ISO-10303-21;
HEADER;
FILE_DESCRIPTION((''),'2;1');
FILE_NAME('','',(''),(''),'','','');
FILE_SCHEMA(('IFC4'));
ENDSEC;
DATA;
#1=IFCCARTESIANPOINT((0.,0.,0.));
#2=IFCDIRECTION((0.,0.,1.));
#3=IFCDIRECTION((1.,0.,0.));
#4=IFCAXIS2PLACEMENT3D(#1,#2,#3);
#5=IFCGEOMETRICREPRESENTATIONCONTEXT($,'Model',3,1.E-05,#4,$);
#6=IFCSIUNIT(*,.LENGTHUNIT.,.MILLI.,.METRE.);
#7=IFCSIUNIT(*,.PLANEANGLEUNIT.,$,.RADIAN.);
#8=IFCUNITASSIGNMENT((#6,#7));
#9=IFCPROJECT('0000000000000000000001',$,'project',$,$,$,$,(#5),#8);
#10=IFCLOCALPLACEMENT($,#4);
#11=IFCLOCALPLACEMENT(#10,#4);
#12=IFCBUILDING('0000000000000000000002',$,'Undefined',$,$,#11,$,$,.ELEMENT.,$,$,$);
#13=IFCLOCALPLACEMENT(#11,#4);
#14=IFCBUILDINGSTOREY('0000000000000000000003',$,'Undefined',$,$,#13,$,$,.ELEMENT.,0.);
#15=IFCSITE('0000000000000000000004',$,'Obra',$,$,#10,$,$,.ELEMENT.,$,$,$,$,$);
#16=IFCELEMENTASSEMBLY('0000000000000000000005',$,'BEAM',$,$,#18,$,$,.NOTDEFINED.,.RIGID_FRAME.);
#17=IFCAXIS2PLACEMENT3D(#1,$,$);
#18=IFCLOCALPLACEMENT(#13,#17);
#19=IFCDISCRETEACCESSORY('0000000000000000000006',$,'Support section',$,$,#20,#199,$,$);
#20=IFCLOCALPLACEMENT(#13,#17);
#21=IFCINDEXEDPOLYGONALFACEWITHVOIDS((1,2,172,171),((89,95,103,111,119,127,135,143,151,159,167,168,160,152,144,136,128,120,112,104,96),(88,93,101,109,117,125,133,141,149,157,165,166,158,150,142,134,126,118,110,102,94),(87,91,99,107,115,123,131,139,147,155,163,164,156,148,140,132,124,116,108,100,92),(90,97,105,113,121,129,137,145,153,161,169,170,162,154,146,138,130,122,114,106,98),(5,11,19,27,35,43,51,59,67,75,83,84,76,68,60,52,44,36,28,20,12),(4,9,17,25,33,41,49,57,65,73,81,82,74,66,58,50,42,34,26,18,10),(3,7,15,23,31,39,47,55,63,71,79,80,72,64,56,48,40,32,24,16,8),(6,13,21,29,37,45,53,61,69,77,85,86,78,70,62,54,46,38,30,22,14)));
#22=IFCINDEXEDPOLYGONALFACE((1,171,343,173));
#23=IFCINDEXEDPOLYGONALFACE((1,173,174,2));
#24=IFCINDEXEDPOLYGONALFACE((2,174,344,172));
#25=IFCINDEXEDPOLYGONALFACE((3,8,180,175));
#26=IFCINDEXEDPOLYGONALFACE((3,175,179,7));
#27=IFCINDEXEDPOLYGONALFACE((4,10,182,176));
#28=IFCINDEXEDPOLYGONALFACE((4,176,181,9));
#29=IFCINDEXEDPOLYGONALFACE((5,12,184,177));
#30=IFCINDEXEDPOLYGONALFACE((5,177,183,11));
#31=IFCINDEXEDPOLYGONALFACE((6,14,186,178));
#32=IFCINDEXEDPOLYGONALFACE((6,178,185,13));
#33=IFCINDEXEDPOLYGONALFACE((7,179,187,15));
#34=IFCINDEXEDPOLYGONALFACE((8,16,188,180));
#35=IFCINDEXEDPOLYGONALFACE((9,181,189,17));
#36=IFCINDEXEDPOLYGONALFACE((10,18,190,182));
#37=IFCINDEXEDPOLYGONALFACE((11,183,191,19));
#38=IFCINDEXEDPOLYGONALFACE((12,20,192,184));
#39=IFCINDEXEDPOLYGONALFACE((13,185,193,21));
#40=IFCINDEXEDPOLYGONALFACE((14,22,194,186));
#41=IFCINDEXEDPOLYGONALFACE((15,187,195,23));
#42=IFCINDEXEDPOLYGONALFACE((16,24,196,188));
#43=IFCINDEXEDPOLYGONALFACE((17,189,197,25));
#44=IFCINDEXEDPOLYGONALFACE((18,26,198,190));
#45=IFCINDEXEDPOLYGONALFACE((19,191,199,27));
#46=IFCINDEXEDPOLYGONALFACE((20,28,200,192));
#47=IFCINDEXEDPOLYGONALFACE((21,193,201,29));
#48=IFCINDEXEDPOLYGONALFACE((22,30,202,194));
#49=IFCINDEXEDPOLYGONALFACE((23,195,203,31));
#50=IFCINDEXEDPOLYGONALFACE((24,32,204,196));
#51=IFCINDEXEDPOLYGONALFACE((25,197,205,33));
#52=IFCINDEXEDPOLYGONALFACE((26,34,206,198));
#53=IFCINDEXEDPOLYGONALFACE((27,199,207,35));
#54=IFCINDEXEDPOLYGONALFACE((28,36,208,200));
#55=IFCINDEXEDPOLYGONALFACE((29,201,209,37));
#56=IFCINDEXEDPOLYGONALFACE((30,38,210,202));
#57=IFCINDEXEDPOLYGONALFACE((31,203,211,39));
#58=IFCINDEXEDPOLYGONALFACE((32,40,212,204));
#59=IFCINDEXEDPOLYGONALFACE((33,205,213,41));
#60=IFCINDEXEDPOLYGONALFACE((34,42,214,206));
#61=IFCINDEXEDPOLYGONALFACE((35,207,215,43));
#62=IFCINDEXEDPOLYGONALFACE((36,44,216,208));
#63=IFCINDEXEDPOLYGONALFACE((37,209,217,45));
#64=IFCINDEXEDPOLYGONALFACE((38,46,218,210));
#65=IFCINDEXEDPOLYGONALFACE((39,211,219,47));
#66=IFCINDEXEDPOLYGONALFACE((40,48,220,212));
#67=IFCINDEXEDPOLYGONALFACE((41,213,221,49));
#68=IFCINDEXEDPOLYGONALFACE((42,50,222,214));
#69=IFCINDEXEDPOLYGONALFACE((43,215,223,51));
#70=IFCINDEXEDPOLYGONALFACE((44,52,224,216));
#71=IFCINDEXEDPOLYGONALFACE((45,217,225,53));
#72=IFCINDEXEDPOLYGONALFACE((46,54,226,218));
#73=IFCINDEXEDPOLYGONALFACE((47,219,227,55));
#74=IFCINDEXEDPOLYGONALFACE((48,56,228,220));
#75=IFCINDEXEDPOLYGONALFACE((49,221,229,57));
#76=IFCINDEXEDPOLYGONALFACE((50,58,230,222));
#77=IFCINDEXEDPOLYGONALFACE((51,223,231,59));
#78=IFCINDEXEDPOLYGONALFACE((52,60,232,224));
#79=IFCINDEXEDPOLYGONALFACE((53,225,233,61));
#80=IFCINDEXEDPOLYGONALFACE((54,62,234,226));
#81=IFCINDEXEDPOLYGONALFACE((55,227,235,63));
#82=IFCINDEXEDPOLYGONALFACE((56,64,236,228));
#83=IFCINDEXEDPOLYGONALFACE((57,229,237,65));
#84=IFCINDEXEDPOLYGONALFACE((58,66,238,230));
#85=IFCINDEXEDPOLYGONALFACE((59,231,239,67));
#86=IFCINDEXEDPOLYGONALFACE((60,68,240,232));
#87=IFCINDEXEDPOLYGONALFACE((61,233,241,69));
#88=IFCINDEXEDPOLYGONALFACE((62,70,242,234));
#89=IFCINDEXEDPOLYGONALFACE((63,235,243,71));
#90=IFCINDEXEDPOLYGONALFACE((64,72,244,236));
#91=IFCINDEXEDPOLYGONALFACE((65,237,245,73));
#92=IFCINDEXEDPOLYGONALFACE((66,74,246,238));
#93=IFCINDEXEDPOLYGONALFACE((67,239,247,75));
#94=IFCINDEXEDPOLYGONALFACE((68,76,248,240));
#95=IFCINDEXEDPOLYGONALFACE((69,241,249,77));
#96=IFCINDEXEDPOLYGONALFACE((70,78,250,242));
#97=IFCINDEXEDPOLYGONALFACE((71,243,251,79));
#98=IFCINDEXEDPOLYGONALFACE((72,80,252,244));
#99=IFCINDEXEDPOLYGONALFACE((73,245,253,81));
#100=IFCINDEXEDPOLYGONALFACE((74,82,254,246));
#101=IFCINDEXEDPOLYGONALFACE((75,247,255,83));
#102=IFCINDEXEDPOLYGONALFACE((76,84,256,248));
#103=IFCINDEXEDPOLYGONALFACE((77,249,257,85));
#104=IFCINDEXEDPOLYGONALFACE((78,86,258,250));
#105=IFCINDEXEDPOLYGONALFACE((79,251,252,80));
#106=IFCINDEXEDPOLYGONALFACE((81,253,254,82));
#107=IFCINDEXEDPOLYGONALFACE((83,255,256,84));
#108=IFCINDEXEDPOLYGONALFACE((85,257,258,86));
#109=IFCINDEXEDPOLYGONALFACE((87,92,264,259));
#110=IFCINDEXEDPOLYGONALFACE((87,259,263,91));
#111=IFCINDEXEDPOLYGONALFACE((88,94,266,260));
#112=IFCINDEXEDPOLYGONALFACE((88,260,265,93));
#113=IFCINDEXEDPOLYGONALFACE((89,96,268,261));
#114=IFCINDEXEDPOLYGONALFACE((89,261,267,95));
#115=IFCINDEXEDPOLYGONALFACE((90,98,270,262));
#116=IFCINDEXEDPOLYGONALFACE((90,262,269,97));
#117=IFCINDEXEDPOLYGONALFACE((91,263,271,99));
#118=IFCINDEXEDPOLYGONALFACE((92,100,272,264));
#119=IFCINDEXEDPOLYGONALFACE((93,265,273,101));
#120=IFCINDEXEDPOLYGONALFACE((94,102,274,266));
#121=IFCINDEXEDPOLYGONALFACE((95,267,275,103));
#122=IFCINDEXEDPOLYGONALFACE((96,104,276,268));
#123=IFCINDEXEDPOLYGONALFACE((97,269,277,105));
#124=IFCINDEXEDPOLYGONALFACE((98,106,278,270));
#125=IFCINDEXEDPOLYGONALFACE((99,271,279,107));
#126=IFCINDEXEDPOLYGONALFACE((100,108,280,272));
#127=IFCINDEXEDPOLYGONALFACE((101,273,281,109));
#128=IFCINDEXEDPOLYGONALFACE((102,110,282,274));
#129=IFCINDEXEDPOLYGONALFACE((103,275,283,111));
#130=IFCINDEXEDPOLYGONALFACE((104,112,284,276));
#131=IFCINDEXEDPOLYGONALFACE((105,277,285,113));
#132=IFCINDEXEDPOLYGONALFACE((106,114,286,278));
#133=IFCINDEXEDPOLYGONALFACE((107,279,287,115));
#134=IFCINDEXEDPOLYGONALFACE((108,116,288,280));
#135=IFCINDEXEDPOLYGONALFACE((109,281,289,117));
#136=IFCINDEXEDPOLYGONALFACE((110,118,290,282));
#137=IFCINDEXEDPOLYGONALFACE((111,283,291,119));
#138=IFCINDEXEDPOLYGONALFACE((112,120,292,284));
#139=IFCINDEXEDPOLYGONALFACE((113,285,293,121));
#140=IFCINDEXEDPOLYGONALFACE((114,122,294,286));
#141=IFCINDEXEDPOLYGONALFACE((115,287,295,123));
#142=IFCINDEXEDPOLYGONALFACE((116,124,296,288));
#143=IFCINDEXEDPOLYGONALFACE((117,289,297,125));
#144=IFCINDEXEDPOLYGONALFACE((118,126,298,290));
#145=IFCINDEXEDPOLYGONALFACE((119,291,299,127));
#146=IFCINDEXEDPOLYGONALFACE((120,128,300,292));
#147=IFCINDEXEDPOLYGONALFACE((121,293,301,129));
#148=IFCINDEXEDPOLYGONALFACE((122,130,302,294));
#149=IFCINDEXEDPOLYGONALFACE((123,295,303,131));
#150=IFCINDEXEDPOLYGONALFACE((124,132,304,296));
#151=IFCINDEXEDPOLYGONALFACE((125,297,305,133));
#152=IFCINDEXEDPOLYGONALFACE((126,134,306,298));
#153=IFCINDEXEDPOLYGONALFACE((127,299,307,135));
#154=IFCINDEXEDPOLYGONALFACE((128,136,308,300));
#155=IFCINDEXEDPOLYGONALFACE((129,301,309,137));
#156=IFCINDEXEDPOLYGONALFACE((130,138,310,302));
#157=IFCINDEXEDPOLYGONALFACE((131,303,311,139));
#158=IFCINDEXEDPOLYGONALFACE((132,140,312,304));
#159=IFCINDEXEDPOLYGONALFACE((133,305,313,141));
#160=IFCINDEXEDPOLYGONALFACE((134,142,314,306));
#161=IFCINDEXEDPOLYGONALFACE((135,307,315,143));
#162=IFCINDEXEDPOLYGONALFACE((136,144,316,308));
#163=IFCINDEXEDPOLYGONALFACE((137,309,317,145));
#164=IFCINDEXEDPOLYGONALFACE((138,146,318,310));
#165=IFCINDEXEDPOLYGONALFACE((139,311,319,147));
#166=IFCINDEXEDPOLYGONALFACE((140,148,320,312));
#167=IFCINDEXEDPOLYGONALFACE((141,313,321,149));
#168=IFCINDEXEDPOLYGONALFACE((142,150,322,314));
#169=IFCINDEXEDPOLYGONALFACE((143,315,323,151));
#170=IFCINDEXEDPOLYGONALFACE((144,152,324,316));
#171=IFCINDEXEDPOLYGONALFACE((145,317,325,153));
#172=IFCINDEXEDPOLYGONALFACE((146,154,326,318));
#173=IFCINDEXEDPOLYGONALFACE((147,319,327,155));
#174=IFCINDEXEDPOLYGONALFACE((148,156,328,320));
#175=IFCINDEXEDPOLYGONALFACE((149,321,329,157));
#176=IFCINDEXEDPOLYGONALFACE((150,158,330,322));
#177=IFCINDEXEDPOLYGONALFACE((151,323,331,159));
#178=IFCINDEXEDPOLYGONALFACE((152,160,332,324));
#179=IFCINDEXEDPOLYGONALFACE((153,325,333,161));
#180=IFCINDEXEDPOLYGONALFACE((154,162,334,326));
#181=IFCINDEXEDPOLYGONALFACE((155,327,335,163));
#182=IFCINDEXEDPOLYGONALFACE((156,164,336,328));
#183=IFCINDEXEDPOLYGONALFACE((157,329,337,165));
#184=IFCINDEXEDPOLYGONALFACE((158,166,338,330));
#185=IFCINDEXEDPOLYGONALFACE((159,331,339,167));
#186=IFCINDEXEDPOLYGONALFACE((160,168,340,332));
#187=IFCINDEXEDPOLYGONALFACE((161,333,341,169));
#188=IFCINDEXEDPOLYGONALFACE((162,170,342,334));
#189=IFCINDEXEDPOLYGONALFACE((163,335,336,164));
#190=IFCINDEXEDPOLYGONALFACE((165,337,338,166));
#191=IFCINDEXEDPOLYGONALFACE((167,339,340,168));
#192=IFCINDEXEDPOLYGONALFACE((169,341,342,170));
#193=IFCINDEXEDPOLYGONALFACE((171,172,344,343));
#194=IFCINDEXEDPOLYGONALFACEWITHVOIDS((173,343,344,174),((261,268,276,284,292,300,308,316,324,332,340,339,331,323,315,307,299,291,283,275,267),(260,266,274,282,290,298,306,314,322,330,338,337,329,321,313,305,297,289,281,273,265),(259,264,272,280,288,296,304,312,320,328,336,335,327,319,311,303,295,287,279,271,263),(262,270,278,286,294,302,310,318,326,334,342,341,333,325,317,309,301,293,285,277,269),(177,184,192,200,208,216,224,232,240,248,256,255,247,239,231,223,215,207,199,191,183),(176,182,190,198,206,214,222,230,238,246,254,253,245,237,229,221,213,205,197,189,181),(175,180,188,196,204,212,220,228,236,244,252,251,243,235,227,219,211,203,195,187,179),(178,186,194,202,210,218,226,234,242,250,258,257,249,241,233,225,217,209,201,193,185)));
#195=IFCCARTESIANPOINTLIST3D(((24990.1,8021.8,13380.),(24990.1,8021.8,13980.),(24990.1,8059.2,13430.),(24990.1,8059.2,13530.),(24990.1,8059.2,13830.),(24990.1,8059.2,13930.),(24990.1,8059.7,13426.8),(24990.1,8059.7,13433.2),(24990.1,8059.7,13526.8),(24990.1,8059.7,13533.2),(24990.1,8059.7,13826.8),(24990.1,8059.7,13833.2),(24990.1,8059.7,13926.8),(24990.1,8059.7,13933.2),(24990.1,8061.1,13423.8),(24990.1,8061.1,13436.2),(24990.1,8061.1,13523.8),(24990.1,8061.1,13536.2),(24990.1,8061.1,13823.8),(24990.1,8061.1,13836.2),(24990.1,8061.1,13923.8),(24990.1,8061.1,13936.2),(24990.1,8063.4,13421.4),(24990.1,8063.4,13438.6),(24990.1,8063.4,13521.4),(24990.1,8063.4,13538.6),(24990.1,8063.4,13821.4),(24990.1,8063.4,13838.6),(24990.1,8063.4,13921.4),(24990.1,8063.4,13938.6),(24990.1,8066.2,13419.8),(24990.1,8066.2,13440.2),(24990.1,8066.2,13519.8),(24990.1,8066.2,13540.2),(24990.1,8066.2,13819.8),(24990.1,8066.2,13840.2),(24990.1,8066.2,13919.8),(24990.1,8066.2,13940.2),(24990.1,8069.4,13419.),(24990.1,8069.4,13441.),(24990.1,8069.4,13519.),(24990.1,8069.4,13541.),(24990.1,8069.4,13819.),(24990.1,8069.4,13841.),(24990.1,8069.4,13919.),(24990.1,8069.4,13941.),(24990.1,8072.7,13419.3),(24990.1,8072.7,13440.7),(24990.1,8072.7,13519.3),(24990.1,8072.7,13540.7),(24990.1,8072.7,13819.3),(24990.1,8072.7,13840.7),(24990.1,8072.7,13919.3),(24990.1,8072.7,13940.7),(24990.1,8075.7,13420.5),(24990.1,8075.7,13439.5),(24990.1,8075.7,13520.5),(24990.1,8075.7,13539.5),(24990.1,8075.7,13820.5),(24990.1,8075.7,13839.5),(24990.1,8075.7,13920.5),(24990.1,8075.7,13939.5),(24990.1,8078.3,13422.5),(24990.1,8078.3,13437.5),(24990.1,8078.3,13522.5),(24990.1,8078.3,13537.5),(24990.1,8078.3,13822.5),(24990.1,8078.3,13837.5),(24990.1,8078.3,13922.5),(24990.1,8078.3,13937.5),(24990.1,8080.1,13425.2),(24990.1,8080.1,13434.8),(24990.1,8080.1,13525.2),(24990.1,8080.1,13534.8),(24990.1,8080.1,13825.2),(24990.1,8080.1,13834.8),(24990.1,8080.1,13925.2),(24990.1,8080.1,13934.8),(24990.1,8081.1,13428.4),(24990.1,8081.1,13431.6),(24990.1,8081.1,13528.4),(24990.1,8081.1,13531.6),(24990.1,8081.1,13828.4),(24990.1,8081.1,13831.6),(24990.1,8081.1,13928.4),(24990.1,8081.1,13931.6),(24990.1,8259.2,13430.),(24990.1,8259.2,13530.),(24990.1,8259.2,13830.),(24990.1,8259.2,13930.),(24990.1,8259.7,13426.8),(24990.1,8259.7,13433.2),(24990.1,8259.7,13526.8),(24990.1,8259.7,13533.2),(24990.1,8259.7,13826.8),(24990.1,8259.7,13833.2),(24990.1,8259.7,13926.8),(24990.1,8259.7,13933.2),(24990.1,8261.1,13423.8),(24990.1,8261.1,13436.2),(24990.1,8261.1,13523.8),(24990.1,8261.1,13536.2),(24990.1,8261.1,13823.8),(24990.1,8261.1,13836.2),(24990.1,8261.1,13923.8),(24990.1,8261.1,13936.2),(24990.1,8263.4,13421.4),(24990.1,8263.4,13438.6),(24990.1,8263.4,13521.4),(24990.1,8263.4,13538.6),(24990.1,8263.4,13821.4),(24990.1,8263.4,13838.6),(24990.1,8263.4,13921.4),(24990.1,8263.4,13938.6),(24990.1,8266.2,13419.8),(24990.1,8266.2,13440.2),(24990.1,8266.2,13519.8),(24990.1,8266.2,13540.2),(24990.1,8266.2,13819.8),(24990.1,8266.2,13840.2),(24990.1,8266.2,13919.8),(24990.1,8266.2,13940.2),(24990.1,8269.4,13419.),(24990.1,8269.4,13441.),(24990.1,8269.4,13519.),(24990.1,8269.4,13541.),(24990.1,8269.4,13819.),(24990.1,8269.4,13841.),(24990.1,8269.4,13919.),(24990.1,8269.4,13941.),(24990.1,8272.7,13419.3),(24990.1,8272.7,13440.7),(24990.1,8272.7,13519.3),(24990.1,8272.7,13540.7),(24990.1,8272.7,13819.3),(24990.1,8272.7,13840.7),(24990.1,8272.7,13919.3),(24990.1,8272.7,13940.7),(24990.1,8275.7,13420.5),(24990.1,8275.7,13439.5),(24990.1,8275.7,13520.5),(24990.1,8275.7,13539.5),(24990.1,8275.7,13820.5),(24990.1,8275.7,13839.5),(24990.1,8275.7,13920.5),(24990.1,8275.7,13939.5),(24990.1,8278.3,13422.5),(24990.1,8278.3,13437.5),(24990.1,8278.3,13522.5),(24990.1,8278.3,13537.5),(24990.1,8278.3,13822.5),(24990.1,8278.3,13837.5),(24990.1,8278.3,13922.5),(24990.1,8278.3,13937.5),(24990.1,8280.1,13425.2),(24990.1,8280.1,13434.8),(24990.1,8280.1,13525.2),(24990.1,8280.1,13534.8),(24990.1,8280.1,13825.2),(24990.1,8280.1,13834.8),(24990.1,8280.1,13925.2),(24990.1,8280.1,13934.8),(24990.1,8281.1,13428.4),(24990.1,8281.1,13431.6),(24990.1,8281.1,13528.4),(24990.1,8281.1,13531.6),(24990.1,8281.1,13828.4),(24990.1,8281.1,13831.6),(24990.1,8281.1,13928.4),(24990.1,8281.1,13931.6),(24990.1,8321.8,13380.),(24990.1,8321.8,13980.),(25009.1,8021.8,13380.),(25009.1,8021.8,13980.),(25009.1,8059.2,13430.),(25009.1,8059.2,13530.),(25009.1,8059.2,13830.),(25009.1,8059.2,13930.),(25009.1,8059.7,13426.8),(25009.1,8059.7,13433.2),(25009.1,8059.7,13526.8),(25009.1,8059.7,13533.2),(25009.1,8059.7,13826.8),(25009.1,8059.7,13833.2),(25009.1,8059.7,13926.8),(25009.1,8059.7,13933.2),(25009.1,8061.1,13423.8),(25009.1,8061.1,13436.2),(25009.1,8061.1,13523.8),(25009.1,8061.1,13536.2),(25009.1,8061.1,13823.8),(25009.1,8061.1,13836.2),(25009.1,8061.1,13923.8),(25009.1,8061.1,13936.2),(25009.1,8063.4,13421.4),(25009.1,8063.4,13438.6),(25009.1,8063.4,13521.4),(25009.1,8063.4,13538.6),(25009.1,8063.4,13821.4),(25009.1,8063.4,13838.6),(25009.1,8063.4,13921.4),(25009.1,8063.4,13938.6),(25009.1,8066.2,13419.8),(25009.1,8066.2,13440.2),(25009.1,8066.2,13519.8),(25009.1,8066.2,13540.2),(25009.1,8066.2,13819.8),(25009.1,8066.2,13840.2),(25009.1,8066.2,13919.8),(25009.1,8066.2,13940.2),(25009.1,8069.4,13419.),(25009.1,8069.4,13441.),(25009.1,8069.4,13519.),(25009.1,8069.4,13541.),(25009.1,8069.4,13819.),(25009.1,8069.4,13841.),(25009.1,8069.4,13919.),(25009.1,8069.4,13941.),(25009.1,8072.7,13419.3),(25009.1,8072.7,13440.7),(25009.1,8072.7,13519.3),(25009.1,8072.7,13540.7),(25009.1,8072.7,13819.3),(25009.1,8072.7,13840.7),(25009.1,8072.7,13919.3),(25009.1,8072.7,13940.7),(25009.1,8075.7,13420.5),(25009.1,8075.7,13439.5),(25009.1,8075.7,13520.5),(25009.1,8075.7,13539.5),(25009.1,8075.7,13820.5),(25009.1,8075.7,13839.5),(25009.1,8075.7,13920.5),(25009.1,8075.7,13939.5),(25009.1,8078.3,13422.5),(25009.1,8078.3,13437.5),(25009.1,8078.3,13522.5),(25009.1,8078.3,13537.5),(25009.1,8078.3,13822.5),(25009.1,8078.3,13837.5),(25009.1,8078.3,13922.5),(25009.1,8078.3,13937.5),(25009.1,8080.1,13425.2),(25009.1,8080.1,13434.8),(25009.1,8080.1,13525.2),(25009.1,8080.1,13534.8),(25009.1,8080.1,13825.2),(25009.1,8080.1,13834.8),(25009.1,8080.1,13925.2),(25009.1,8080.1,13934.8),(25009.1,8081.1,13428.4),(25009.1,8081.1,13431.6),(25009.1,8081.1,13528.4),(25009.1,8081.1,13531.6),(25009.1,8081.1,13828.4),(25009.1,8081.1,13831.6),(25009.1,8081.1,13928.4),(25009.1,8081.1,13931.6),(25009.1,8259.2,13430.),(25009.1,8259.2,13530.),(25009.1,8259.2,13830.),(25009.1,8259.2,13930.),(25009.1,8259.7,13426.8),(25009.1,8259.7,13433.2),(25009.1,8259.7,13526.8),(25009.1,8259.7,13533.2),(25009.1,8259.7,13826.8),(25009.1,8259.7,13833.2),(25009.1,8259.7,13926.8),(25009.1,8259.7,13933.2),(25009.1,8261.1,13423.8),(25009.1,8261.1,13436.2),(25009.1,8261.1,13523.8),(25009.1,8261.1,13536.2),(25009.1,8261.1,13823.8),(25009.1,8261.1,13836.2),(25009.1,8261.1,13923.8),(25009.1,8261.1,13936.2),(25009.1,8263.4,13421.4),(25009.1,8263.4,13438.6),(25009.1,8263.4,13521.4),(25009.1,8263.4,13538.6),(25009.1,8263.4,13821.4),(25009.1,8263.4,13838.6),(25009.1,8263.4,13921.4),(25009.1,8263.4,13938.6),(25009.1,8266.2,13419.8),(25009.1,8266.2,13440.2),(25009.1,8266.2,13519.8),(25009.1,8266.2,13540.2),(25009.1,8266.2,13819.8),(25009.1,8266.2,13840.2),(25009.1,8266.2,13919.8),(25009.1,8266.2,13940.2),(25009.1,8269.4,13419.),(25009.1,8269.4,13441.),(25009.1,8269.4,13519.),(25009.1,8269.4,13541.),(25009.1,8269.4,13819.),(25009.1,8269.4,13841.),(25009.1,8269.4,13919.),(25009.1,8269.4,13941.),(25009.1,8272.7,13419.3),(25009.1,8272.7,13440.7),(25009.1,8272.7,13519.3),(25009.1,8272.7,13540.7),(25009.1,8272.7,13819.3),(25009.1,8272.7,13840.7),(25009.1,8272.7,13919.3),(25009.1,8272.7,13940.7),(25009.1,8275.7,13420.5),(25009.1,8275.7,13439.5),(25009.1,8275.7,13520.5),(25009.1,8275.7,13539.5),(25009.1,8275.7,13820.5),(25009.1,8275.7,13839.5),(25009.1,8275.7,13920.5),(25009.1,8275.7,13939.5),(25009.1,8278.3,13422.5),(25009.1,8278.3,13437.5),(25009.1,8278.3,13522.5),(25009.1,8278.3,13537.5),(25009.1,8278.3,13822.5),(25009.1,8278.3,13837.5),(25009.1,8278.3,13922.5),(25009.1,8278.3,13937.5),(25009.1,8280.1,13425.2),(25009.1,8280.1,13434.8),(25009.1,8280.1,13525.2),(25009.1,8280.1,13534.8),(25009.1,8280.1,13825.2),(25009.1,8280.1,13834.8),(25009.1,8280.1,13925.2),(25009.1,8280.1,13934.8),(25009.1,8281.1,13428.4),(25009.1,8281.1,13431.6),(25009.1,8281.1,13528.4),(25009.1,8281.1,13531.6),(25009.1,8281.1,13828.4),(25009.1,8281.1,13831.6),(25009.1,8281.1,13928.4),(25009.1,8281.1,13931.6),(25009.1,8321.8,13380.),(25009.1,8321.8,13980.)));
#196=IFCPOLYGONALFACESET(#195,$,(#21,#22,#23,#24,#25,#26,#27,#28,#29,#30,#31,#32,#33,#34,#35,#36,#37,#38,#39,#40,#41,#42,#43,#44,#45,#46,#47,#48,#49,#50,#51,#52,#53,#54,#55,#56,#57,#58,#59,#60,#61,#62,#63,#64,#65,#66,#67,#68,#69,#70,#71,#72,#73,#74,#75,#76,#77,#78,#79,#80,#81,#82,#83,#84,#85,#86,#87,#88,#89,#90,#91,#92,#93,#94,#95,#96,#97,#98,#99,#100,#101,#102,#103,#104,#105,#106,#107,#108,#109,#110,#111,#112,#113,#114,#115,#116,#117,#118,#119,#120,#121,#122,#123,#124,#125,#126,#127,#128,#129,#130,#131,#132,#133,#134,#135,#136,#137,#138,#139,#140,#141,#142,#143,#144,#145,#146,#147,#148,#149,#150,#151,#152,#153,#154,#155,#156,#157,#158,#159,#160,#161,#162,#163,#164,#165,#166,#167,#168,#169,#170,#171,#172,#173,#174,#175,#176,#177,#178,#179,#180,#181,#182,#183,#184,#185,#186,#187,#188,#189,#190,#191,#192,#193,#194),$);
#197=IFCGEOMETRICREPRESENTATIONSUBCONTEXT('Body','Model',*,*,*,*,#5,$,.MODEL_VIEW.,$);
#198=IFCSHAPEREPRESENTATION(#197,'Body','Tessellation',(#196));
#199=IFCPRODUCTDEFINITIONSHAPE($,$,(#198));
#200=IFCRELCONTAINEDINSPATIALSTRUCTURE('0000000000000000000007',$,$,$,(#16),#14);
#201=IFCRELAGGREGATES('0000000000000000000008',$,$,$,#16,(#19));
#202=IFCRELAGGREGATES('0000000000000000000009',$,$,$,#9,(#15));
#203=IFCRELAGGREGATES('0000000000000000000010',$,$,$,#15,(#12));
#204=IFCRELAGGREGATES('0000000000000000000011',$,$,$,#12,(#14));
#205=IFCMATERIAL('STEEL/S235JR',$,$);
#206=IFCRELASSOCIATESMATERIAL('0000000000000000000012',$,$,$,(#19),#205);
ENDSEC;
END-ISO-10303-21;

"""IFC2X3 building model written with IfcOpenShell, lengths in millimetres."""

from ifc_helpers import new_model, si_unit, frame, origin_with_axes, origin_2d_with_axis, place, context, subcontext, project, spatial, rectangle, circle, extrude, source, transform, mapped, material, element, aggregate, save


model = new_model("IFC2X3")

# Units and contexts
model_context = context("Model", 3, precision=1e-05, world=origin_with_axes())
body_context = subcontext(model_context, "Body", "Model", "MODEL_VIEW")
ifc_project = project(units=[si_unit("LENGTHUNIT", "METRE", prefix="MILLI"), si_unit("PLANEANGLEUNIT", "RADIAN")], contexts=[model_context])

# Site, building, storey
site_placement = place(None, origin_with_axes())
site = spatial("IfcSite", under=ifc_project, at=site_placement, Name="Obra", CompositionType="ELEMENT")
building_placement = place(site_placement, origin_with_axes())
building = spatial("IfcBuilding", under=site, at=building_placement, Name="Undefined", CompositionType="ELEMENT")
storey_placement = place(building_placement, origin_with_axes())
storey = spatial("IfcBuildingStorey", under=building, at=storey_placement, Name="Undefined", CompositionType="ELEMENT", Elevation=0.0)

# Shared definitions
ifc_material_1 = material(Name="STEEL/S235JR")

# Element assembly, discrete accessory, opening
assembly_1_placement = place(storey_placement, origin_with_axes())
assembly_1 = element("IfcElementAssembly", 1, at=assembly_1_placement, inside=storey, Name="BEAM", AssemblyPlace="NOTDEFINED", PredefinedType="RIGID_FRAME")
discrete_accessory_1_placement = place(assembly_1_placement, frame((24999.6, 8021.8, 13680.0), z_axis=(0.0, 0.0, 1.0), x_axis=(0.0, 1.0, 0.0)))
discrete_accessory_1 = element("IfcDiscreteAccessory", 2, at=discrete_accessory_1_placement, material=ifc_material_1, Name="Support section", context=body_context, shape_type="SweptSolid", body=[
    extrude(rectangle(XDim=19.0, YDim=600.0, at=origin_2d_with_axis()), frame((300.0, 0.0, 0.0), z_axis=(-1.0, 0.0, 0.0), x_axis=(0.0, -1.0, 0.0)), (0.0, 0.0, 1.0), 300.0),
])
shared_shape_1 = source(origin_with_axes(), body_context, "Body", "SweptSolid", [
    extrude(circle(Radius=11.0, at=origin_2d_with_axis()), frame((0.0, -19.1, 0.0), z_axis=(0.0, 1.0, 0.0), x_axis=(1.0, 0.0, 0.0)), (0.0, 0.0, 1.0), 19.2),
])
opening_1_placement = place(assembly_1_placement, frame((25009.1, 8320.2, 13680.0), z_axis=(0.0, 0.0, 1.0), x_axis=(0.0, -1.0, 0.0)))
element("IfcOpeningElement", 3, at=opening_1_placement, cuts=discrete_accessory_1, ObjectType="Opening", context=body_context, shape_type="MappedRepresentation", body=[
    mapped(shared_shape_1, transform((50.0, 0.0, -250.0))),
    mapped(shared_shape_1, transform((50.0, 0.0, -150.0))),
    mapped(shared_shape_1, transform((50.0, 0.0, 150.0))),
    mapped(shared_shape_1, transform((50.0, 0.0, 250.0))),
    mapped(shared_shape_1, transform((250.0, 0.0, -250.0))),
    mapped(shared_shape_1, transform((250.0, 0.0, -150.0))),
    mapped(shared_shape_1, transform((250.0, 0.0, 150.0))),
    mapped(shared_shape_1, transform((250.0, 0.0, 250.0))),
])
aggregate(assembly_1, [discrete_accessory_1])

save(model, "model.ifc")
